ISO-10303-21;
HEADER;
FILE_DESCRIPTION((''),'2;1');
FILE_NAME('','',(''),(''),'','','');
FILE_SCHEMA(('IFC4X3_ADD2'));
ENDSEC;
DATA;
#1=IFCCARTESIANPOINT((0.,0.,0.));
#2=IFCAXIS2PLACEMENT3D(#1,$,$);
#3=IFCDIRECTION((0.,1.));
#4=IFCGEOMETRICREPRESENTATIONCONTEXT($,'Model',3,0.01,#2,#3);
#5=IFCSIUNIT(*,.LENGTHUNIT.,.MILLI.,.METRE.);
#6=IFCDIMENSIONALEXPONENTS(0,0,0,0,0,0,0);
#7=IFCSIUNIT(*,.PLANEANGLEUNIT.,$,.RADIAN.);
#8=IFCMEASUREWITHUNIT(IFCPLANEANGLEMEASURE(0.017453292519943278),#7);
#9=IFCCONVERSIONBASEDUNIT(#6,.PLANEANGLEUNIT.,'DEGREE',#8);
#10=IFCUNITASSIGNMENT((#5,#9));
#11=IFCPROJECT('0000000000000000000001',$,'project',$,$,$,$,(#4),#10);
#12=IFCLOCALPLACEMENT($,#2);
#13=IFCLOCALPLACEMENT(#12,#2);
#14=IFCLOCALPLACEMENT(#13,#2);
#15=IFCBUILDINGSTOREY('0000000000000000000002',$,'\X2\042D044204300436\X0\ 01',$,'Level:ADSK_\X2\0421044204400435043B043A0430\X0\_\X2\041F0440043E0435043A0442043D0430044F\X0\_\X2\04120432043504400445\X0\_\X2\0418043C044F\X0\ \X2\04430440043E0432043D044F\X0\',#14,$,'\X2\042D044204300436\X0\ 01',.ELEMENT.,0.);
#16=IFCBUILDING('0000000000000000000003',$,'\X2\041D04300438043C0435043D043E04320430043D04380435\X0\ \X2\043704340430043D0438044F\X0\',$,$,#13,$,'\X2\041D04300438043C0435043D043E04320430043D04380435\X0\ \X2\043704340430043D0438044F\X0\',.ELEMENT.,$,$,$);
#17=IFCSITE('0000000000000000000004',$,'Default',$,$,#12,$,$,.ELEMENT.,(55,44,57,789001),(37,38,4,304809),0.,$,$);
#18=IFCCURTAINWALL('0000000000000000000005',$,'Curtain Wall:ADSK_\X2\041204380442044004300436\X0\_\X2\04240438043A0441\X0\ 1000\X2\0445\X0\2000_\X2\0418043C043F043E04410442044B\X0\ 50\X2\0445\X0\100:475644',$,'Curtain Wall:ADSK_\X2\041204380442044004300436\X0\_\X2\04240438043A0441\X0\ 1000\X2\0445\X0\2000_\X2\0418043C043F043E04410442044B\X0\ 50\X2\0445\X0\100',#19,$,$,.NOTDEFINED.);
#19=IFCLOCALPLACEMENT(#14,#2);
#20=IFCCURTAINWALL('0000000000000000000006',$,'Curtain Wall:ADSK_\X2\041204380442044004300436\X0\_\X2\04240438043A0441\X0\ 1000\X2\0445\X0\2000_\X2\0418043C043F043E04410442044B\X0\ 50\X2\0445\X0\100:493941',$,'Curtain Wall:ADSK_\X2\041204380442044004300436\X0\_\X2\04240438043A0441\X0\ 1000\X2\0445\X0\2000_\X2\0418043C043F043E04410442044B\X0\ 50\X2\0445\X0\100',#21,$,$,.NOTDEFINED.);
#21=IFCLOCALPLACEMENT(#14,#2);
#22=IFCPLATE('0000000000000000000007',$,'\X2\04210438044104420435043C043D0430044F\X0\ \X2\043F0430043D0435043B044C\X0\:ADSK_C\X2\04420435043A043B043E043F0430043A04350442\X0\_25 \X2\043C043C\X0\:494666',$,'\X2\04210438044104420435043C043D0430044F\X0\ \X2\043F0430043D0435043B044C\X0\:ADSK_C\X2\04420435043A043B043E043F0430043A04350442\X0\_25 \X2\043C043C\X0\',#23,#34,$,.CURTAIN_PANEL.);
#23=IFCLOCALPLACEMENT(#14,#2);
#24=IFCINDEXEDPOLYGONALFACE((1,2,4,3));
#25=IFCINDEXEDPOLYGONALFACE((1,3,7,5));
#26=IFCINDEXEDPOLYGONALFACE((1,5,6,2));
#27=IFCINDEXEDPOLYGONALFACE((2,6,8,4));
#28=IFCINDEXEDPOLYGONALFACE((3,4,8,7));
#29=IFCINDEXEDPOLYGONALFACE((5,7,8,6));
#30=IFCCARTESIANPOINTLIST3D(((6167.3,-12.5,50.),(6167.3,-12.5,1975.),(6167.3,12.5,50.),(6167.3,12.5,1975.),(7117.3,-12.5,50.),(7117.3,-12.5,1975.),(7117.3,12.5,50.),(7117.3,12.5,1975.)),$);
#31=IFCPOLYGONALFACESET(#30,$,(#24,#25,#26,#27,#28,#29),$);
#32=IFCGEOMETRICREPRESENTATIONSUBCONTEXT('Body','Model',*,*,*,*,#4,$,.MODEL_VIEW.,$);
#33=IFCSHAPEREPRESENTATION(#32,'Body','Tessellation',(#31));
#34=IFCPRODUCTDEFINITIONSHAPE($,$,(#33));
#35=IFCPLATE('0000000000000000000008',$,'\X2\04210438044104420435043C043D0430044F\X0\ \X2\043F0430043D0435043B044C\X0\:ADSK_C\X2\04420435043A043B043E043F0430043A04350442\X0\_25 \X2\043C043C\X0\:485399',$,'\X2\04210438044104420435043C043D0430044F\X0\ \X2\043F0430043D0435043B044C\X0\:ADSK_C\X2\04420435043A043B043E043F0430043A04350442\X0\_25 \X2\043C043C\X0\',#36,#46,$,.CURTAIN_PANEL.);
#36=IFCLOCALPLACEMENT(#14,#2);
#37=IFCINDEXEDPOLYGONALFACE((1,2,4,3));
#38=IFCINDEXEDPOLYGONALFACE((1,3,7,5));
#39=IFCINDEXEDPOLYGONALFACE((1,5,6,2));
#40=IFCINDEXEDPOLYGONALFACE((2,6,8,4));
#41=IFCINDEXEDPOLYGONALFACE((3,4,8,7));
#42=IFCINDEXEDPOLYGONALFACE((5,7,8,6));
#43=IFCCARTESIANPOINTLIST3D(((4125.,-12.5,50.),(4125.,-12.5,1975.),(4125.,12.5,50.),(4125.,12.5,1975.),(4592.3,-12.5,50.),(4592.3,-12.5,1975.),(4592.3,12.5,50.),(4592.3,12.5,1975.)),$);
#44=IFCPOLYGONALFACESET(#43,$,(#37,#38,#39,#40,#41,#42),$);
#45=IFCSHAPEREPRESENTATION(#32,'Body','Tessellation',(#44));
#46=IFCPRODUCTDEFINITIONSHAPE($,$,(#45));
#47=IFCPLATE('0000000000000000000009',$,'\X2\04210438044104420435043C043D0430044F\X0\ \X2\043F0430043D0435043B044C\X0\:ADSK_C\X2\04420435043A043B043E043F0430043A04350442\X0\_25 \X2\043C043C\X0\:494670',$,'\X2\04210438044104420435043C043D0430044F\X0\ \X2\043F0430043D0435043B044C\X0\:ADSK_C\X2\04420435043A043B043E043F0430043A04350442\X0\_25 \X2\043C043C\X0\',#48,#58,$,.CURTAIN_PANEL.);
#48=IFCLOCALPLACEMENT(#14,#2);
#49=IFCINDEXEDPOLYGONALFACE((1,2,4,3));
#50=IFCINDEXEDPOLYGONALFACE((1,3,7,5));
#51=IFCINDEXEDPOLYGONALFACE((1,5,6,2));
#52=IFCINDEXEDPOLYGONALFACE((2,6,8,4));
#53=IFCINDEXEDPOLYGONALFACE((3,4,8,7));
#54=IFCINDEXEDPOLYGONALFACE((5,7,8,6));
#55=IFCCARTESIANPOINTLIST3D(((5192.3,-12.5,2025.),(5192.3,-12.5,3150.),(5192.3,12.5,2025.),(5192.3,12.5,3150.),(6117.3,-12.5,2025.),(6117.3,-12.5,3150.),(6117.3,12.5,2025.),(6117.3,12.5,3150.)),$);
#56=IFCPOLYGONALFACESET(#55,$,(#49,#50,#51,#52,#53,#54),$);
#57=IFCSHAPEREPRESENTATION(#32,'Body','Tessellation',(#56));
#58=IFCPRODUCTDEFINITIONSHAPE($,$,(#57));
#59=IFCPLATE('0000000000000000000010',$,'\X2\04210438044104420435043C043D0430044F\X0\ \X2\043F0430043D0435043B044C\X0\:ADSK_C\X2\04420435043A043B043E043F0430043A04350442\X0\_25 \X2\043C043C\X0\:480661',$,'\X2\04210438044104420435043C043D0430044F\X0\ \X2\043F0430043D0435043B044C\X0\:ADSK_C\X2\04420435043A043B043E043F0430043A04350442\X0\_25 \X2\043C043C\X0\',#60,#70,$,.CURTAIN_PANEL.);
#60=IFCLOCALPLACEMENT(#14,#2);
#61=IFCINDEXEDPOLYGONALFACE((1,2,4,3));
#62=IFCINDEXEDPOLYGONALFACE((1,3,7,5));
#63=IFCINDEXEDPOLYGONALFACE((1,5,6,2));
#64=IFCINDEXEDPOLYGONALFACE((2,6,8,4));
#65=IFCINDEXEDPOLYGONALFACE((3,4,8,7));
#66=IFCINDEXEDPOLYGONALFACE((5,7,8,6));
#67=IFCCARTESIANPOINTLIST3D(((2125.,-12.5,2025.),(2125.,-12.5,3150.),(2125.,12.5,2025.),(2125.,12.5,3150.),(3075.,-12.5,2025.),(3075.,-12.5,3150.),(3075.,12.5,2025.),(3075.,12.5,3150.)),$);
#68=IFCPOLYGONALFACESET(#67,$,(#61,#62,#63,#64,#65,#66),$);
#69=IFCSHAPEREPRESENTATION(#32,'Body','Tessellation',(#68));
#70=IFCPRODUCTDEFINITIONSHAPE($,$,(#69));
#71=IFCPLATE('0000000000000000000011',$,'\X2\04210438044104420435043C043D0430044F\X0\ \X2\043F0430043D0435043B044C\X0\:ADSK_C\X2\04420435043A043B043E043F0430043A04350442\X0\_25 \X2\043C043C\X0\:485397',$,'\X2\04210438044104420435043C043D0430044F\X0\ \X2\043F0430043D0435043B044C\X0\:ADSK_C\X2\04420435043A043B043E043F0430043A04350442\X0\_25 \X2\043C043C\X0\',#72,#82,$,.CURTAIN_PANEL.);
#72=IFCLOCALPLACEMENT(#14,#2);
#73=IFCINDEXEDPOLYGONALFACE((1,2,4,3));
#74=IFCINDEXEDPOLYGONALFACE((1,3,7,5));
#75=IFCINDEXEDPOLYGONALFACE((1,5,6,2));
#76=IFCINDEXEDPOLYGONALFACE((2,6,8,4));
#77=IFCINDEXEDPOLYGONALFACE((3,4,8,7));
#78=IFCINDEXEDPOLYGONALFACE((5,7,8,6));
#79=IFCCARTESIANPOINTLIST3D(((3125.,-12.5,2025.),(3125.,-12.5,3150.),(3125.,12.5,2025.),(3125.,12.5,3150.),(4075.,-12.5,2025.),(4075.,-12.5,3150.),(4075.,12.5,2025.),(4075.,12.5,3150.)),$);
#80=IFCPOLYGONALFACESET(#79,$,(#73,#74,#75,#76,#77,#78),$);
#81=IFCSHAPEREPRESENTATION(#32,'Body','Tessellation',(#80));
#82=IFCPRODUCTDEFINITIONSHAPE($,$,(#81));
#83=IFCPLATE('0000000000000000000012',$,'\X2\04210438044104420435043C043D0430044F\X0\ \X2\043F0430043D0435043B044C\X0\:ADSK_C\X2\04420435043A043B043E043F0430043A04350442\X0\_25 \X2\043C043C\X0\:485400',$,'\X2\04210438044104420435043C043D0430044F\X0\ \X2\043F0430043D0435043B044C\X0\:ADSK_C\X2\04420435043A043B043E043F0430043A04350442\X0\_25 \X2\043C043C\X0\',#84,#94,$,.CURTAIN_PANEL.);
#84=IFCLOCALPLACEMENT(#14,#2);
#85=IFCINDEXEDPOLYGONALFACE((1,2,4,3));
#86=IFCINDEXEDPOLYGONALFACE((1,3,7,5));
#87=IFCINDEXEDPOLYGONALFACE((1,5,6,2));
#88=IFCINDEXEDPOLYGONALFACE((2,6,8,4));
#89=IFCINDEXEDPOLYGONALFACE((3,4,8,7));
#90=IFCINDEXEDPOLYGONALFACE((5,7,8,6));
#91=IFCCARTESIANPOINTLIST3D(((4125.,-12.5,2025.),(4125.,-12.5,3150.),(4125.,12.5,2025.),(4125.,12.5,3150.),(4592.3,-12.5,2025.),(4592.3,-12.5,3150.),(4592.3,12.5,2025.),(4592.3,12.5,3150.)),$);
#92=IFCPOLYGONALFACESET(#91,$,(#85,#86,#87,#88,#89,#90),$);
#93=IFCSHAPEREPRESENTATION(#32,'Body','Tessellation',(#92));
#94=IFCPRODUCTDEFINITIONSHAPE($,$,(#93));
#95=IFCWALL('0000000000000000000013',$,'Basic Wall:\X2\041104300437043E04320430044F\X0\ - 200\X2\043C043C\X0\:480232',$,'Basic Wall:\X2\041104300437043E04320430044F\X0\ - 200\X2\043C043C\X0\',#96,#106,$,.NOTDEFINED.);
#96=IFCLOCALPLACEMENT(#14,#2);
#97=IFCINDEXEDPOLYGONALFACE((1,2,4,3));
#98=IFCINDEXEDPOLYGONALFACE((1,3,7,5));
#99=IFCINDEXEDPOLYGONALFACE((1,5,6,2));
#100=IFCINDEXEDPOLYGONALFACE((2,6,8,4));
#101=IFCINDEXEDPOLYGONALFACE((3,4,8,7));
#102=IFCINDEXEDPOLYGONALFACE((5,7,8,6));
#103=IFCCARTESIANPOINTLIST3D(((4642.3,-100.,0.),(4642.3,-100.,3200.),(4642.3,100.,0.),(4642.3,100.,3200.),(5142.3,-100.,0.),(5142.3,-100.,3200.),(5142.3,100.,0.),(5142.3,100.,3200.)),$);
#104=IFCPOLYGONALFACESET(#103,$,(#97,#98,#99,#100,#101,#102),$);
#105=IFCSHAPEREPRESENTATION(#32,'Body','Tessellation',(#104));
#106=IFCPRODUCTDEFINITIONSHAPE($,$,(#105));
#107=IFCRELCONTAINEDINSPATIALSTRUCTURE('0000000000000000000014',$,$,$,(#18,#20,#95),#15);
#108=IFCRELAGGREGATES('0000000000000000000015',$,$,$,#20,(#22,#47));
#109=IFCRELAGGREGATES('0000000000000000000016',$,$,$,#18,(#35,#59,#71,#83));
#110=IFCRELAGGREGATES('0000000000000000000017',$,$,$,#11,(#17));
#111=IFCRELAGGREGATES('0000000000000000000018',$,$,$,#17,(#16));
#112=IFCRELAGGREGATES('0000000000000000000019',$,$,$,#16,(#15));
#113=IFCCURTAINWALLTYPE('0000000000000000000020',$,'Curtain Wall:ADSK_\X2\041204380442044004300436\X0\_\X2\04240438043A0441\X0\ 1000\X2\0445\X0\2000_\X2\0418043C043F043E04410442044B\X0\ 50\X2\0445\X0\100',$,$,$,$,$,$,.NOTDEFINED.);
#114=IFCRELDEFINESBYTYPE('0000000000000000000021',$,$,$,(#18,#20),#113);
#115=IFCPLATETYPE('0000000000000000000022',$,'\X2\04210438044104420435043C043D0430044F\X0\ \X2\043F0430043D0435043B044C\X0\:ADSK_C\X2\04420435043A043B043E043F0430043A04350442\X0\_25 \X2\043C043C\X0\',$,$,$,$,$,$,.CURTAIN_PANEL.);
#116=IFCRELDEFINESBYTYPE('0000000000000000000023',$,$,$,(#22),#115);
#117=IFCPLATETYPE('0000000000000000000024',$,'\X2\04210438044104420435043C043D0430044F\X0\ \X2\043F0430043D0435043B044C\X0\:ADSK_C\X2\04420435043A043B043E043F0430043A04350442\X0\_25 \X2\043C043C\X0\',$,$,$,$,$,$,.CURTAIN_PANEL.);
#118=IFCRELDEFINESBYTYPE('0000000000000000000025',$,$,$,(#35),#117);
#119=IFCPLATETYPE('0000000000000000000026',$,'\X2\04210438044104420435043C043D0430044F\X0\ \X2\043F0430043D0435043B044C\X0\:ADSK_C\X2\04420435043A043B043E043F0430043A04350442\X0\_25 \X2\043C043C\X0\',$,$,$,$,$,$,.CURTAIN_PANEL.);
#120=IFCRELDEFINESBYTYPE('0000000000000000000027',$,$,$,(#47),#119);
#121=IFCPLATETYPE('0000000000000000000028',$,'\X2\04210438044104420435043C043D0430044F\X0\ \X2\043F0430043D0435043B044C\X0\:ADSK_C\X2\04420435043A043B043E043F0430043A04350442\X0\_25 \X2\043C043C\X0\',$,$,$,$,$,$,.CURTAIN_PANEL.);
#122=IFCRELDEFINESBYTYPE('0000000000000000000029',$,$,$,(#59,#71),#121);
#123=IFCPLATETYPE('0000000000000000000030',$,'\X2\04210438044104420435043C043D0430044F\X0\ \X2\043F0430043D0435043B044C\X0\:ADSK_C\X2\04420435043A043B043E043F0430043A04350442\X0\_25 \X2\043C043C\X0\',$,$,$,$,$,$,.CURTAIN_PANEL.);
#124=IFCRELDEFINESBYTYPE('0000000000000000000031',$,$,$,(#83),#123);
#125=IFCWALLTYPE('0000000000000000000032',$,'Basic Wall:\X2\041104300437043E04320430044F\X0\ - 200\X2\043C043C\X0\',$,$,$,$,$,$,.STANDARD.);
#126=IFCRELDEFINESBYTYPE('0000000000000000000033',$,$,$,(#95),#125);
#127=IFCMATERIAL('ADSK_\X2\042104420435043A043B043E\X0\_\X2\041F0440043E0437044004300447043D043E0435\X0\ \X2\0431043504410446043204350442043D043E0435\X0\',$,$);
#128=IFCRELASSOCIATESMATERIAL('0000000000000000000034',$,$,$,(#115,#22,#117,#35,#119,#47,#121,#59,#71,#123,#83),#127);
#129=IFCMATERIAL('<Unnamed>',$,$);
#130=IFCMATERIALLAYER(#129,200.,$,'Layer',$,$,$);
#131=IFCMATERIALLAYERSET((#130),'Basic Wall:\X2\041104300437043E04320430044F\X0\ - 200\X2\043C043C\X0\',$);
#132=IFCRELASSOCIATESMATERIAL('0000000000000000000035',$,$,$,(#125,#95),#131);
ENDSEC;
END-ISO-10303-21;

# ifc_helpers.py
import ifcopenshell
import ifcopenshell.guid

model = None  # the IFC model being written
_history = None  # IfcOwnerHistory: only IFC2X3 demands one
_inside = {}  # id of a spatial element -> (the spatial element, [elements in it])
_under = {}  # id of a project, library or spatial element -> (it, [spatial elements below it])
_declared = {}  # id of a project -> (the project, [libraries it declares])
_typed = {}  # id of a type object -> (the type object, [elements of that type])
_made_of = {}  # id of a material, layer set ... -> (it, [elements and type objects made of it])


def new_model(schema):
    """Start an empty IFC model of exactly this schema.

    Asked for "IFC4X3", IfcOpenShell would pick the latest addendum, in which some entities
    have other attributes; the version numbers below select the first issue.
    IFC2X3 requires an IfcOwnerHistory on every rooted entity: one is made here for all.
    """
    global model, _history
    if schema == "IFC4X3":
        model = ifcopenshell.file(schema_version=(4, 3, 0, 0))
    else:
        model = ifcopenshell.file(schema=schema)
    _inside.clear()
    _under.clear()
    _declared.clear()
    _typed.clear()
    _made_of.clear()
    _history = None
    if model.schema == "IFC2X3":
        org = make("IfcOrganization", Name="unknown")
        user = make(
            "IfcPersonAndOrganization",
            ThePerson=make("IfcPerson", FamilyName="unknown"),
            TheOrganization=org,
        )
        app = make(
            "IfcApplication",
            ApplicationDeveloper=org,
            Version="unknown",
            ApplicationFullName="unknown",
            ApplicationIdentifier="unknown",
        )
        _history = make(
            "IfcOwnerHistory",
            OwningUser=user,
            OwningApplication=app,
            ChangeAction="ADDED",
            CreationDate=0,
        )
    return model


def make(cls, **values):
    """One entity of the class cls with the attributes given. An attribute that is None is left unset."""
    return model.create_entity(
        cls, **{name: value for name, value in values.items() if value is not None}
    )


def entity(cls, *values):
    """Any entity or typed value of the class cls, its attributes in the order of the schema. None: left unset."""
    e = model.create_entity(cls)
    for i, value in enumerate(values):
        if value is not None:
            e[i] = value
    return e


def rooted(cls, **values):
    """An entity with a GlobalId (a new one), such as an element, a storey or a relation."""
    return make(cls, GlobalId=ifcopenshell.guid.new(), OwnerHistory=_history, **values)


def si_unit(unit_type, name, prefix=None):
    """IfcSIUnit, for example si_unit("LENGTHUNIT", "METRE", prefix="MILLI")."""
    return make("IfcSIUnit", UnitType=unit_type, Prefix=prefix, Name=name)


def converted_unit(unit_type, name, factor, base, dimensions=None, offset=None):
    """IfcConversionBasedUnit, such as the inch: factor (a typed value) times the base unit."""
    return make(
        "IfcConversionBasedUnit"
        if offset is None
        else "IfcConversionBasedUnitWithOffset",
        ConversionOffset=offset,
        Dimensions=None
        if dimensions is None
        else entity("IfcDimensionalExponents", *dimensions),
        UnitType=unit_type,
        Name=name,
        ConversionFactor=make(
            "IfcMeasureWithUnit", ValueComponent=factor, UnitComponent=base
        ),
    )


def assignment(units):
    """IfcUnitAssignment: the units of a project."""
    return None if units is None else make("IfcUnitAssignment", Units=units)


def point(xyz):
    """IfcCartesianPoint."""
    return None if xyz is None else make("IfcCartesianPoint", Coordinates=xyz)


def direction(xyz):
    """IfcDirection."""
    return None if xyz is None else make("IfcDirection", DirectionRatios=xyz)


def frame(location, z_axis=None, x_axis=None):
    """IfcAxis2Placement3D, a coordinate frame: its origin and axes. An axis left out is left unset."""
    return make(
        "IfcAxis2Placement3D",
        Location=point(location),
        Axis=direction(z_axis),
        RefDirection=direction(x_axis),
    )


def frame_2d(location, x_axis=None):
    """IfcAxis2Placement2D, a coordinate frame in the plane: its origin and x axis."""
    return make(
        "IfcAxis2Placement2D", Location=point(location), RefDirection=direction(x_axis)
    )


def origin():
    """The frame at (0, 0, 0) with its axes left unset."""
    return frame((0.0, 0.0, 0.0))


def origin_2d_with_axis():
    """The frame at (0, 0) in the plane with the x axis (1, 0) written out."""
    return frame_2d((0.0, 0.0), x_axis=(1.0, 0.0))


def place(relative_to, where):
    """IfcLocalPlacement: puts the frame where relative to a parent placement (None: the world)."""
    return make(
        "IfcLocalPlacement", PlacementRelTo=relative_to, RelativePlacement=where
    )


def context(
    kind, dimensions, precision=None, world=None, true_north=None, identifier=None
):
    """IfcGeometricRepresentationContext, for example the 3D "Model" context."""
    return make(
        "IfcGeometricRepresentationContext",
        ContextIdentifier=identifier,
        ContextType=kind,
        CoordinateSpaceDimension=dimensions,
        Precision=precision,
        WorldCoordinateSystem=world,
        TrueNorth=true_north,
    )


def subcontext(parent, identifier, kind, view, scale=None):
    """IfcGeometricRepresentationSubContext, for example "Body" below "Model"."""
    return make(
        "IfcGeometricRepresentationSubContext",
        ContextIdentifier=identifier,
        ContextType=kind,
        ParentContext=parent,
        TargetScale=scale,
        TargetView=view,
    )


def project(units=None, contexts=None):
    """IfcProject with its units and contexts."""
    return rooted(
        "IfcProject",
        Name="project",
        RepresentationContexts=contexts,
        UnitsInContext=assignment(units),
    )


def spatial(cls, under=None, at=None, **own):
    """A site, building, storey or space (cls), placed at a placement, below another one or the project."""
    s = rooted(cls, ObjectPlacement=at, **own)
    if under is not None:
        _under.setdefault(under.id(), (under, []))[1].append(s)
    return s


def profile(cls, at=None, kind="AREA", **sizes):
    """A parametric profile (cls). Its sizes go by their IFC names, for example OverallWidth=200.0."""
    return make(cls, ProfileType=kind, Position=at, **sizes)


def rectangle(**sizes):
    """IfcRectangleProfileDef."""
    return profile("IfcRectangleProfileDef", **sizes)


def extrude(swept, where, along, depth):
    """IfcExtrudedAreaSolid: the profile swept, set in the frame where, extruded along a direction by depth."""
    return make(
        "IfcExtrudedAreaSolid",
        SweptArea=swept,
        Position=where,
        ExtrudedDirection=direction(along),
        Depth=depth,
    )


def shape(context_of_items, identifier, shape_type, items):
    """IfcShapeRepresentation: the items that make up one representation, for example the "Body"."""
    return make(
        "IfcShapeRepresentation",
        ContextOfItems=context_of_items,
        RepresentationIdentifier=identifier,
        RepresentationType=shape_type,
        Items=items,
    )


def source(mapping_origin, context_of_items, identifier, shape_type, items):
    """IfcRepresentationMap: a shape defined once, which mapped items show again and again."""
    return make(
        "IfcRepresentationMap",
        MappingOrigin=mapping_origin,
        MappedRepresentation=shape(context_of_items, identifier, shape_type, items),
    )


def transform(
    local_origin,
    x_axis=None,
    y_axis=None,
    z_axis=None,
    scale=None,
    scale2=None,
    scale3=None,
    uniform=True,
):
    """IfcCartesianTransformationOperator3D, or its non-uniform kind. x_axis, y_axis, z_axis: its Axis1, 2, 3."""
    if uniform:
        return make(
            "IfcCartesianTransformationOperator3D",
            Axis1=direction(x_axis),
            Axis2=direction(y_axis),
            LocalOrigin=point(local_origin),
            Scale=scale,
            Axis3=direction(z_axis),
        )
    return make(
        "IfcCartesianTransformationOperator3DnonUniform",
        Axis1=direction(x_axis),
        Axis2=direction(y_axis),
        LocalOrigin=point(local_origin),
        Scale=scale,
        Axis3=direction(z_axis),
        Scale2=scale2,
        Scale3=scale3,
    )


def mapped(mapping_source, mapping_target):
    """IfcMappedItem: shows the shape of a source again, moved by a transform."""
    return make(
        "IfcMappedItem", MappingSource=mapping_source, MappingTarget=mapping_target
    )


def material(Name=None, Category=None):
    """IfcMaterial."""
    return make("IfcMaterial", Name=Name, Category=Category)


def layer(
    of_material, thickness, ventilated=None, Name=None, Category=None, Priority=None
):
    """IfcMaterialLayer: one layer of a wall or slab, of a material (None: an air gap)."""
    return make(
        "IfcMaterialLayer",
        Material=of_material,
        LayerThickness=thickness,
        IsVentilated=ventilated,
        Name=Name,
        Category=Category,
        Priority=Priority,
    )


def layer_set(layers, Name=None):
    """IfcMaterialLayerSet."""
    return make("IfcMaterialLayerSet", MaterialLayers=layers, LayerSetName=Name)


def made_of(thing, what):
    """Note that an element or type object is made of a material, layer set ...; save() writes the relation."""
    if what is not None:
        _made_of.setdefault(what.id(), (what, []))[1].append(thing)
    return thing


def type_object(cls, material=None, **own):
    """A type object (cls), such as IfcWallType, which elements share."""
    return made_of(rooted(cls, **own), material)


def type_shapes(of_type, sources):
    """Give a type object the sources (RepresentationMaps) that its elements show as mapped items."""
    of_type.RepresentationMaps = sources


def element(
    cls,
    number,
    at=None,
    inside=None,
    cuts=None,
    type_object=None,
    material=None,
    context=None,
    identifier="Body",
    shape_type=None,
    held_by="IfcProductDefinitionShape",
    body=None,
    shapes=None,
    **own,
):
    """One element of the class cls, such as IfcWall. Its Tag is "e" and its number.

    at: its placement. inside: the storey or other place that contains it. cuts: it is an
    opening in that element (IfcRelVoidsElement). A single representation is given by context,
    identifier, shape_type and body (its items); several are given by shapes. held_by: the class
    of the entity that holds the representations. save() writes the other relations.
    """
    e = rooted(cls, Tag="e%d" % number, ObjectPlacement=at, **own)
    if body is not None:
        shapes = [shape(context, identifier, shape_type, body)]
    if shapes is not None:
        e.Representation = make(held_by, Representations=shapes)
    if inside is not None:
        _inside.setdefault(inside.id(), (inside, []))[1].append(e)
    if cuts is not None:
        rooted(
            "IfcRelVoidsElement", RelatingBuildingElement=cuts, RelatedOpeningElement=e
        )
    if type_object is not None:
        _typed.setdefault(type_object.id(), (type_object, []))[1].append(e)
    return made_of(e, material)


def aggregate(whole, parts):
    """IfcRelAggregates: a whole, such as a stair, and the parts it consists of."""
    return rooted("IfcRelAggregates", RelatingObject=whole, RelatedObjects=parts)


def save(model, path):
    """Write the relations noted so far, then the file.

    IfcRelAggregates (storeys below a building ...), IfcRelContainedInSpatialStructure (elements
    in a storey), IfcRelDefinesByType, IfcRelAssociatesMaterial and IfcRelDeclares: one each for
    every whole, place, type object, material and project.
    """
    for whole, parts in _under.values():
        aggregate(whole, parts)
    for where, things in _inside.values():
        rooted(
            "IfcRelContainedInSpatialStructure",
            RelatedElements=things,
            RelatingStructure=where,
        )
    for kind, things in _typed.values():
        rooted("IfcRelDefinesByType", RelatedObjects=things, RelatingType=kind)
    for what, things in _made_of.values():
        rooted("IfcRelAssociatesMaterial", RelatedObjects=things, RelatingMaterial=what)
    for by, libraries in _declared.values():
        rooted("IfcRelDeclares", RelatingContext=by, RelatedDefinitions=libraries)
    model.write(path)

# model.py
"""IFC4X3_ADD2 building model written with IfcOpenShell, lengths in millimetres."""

from ifc_helpers import new_model, entity, si_unit, converted_unit, direction, frame, frame_2d, origin, origin_2d_with_axis, place, context, subcontext, project, spatial, rectangle, extrude, source, transform, mapped, material, layer, layer_set, type_object, type_shapes, element, aggregate, save


model = new_model("IFC4X3_ADD2")

# Units and contexts
model_context = context("Model", 3, precision=0.01, world=origin(), true_north=direction((0.0, 1.0)))
body_context = subcontext(model_context, "Body", "Model", "MODEL_VIEW")
ifc_project = project(units=[si_unit("LENGTHUNIT", "METRE", prefix="MILLI"), converted_unit("PLANEANGLEUNIT", "DEGREE", entity("IfcPlaneAngleMeasure", 0.017453292519943278), si_unit("PLANEANGLEUNIT", "RADIAN"), dimensions=[0, 0, 0, 0, 0, 0, 0])], contexts=[model_context])

# Site, building, storey
site_placement = place(None, origin())
site = spatial("IfcSite", under=ifc_project, at=site_placement, Name="Default", CompositionType="ELEMENT", RefLatitude=(55, 44, 57, 789001), RefLongitude=(37, 38, 4, 304809), RefElevation=0.0)
building_placement = place(site_placement, origin())
building = spatial("IfcBuilding", under=site, at=building_placement, Name="Наименование здания", LongName="Наименование здания", CompositionType="ELEMENT")
storey_placement = place(building_placement, origin())
storey = spatial("IfcBuildingStorey", under=building, at=storey_placement, Name="Этаж 01", ObjectType="Level:ADSK_Стрелка_Проектная_Вверх_Имя уровня", LongName="Этаж 01", CompositionType="ELEMENT", Elevation=0.0)

# Curtain walls
curtain_wall_type = type_object("IfcCurtainWallType", Name="Curtain Wall:ADSK_Витраж_Фикс 1000х2000_Импосты 50х100", PredefinedType="NOTDEFINED")
curtain_wall_1_placement = place(storey_placement, origin())
curtain_wall_1 = element("IfcCurtainWall", 1, at=curtain_wall_1_placement, inside=storey, type_object=curtain_wall_type, Name="Curtain Wall:ADSK_Витраж_Фикс 1000х2000_Импосты 50х100:475644", ObjectType="Curtain Wall:ADSK_Витраж_Фикс 1000х2000_Импосты 50х100", PredefinedType="NOTDEFINED")
ifc_material_1 = material(Name="ADSK_Стекло_Прозрачное бесцветное")
curtain_wall_2_placement = place(storey_placement, origin())
curtain_wall_2 = element("IfcCurtainWall", 2, at=curtain_wall_2_placement, inside=storey, type_object=curtain_wall_type, Name="Curtain Wall:ADSK_Витраж_Фикс 1000х2000_Импосты 50х100:493941", ObjectType="Curtain Wall:ADSK_Витраж_Фикс 1000х2000_Импосты 50х100", PredefinedType="NOTDEFINED")

# Plates
plate_type_1 = type_object("IfcPlateType", Name="Системная панель:ADSK_Cтеклопакет_25 мм", PredefinedType="CURTAIN_PANEL", material=ifc_material_1)
shared_shape_1 = source(origin(), body_context, "Body", "SweptSolid", [
    extrude(rectangle(XDim=25.0, YDim=950.0, at=origin_2d_with_axis()), frame((0.0, 0.0, 0.0), z_axis=(0.0, 0.0, 1.0), x_axis=(0.0, 1.0, 0.0)), (0.0, 0.0, 1.0), 1925.0),
])
type_shapes(plate_type_1, [shared_shape_1])
plate_1_placement = place(curtain_wall_2_placement, frame((6642.3, 0.0, 50.0)))
plate_1 = element("IfcPlate", 3, at=plate_1_placement, type_object=plate_type_1, material=ifc_material_1, Name="Системная панель:ADSK_Cтеклопакет_25 мм:494666", ObjectType="Системная панель:ADSK_Cтеклопакет_25 мм", PredefinedType="CURTAIN_PANEL", context=body_context, shape_type="MappedRepresentation", body=[
    mapped(shared_shape_1, transform((0.0, 0.0, 0.0), scale=1.0)),
])
plate_type_2 = type_object("IfcPlateType", Name="Системная панель:ADSK_Cтеклопакет_25 мм", PredefinedType="CURTAIN_PANEL", material=ifc_material_1)
shared_shape_2 = source(origin(), body_context, "Body", "SweptSolid", [
    extrude(rectangle(XDim=25.0, YDim=467.3, at=origin_2d_with_axis()), frame((0.0, 0.0, 0.0), z_axis=(0.0, 0.0, 1.0), x_axis=(0.0, 1.0, 0.0)), (0.0, 0.0, 1.0), 1925.0),
])
type_shapes(plate_type_2, [shared_shape_2])
plate_2_placement = place(curtain_wall_1_placement, frame((4358.6, 0.0, 50.0)))
plate_2 = element("IfcPlate", 4, at=plate_2_placement, type_object=plate_type_2, material=ifc_material_1, Name="Системная панель:ADSK_Cтеклопакет_25 мм:485399", ObjectType="Системная панель:ADSK_Cтеклопакет_25 мм", PredefinedType="CURTAIN_PANEL", context=body_context, shape_type="MappedRepresentation", body=[
    mapped(shared_shape_2, transform((0.0, 0.0, 0.0), scale=1.0)),
])
plate_type_3 = type_object("IfcPlateType", Name="Системная панель:ADSK_Cтеклопакет_25 мм", PredefinedType="CURTAIN_PANEL", material=ifc_material_1)
shared_shape_3 = source(origin(), body_context, "Body", "SweptSolid", [
    extrude(rectangle(XDim=25.0, YDim=925.0, at=origin_2d_with_axis()), frame((0.0, 0.0, 0.0), z_axis=(0.0, 0.0, 1.0), x_axis=(0.0, 1.0, 0.0)), (0.0, 0.0, 1.0), 1125.0),
])
type_shapes(plate_type_3, [shared_shape_3])
plate_3_placement = place(curtain_wall_2_placement, frame((5654.8, 0.0, 2025.0)))
plate_3 = element("IfcPlate", 5, at=plate_3_placement, type_object=plate_type_3, material=ifc_material_1, Name="Системная панель:ADSK_Cтеклопакет_25 мм:494670", ObjectType="Системная панель:ADSK_Cтеклопакет_25 мм", PredefinedType="CURTAIN_PANEL", context=body_context, shape_type="MappedRepresentation", body=[
    mapped(shared_shape_3, transform((0.0, 0.0, 0.0), scale=1.0)),
])
aggregate(curtain_wall_2, [plate_1, plate_3])
plate_type_4 = type_object("IfcPlateType", Name="Системная панель:ADSK_Cтеклопакет_25 мм", PredefinedType="CURTAIN_PANEL", material=ifc_material_1)
shared_shape_4 = source(origin(), body_context, "Body", "SweptSolid", [
    extrude(rectangle(XDim=25.0, YDim=950.0, at=origin_2d_with_axis()), frame((0.0, 0.0, 0.0), z_axis=(0.0, 0.0, 1.0), x_axis=(0.0, 1.0, 0.0)), (0.0, 0.0, 1.0), 1125.0),
])
type_shapes(plate_type_4, [shared_shape_4])
plate_4_placement = place(curtain_wall_1_placement, frame((2600.0, 0.0, 2025.0)))
plate_4 = element("IfcPlate", 6, at=plate_4_placement, type_object=plate_type_4, material=ifc_material_1, Name="Системная панель:ADSK_Cтеклопакет_25 мм:480661", ObjectType="Системная панель:ADSK_Cтеклопакет_25 мм", PredefinedType="CURTAIN_PANEL", context=body_context, shape_type="MappedRepresentation", body=[
    mapped(shared_shape_4, transform((0.0, 0.0, 0.0), scale=1.0)),
])
plate_5_placement = place(curtain_wall_1_placement, frame((3600.0, 0.0, 2025.0)))
plate_5 = element("IfcPlate", 7, at=plate_5_placement, type_object=plate_type_4, material=ifc_material_1, Name="Системная панель:ADSK_Cтеклопакет_25 мм:485397", ObjectType="Системная панель:ADSK_Cтеклопакет_25 мм", PredefinedType="CURTAIN_PANEL", context=body_context, shape_type="MappedRepresentation", body=[
    mapped(shared_shape_4, transform((0.0, 0.0, 0.0), scale=1.0)),
])
plate_type_5 = type_object("IfcPlateType", Name="Системная панель:ADSK_Cтеклопакет_25 мм", PredefinedType="CURTAIN_PANEL", material=ifc_material_1)
shared_shape_5 = source(origin(), body_context, "Body", "SweptSolid", [
    extrude(rectangle(XDim=25.0, YDim=467.3, at=origin_2d_with_axis()), frame((0.0, 0.0, 0.0), z_axis=(0.0, 0.0, 1.0), x_axis=(0.0, 1.0, 0.0)), (0.0, 0.0, 1.0), 1125.0),
])
type_shapes(plate_type_5, [shared_shape_5])
plate_6_placement = place(curtain_wall_1_placement, frame((4358.6, 0.0, 2025.0)))
plate_6 = element("IfcPlate", 8, at=plate_6_placement, type_object=plate_type_5, material=ifc_material_1, Name="Системная панель:ADSK_Cтеклопакет_25 мм:485400", ObjectType="Системная панель:ADSK_Cтеклопакет_25 мм", PredefinedType="CURTAIN_PANEL", context=body_context, shape_type="MappedRepresentation", body=[
    mapped(shared_shape_5, transform((0.0, 0.0, 0.0), scale=1.0)),
])
aggregate(curtain_wall_1, [plate_2, plate_4, plate_5, plate_6])

# Wall
ifc_material_2 = material(Name="<Unnamed>")
ifc_layer = layer(ifc_material_2, 200.0, Name="Layer")
ifc_layer_set = layer_set([ifc_layer], Name="Basic Wall:Базовая - 200мм")
wall_type = type_object("IfcWallType", Name="Basic Wall:Базовая - 200мм", PredefinedType="STANDARD", material=ifc_layer_set)
wall_placement = place(storey_placement, frame((4642.3, 0.0, 0.0)))
element("IfcWall", 9, at=wall_placement, inside=storey, type_object=wall_type, material=ifc_layer_set, Name="Basic Wall:Базовая - 200мм:480232", ObjectType="Basic Wall:Базовая - 200мм", PredefinedType="NOTDEFINED", context=body_context, shape_type="SweptSolid", body=[
    extrude(rectangle(XDim=500.0, YDim=200.0, at=frame_2d((250.0, 0.0), x_axis=(-1.0, 0.0))), origin(), (0.0, 0.0, 1.0), 3200.0),
])

save(model, "model.ifc")
